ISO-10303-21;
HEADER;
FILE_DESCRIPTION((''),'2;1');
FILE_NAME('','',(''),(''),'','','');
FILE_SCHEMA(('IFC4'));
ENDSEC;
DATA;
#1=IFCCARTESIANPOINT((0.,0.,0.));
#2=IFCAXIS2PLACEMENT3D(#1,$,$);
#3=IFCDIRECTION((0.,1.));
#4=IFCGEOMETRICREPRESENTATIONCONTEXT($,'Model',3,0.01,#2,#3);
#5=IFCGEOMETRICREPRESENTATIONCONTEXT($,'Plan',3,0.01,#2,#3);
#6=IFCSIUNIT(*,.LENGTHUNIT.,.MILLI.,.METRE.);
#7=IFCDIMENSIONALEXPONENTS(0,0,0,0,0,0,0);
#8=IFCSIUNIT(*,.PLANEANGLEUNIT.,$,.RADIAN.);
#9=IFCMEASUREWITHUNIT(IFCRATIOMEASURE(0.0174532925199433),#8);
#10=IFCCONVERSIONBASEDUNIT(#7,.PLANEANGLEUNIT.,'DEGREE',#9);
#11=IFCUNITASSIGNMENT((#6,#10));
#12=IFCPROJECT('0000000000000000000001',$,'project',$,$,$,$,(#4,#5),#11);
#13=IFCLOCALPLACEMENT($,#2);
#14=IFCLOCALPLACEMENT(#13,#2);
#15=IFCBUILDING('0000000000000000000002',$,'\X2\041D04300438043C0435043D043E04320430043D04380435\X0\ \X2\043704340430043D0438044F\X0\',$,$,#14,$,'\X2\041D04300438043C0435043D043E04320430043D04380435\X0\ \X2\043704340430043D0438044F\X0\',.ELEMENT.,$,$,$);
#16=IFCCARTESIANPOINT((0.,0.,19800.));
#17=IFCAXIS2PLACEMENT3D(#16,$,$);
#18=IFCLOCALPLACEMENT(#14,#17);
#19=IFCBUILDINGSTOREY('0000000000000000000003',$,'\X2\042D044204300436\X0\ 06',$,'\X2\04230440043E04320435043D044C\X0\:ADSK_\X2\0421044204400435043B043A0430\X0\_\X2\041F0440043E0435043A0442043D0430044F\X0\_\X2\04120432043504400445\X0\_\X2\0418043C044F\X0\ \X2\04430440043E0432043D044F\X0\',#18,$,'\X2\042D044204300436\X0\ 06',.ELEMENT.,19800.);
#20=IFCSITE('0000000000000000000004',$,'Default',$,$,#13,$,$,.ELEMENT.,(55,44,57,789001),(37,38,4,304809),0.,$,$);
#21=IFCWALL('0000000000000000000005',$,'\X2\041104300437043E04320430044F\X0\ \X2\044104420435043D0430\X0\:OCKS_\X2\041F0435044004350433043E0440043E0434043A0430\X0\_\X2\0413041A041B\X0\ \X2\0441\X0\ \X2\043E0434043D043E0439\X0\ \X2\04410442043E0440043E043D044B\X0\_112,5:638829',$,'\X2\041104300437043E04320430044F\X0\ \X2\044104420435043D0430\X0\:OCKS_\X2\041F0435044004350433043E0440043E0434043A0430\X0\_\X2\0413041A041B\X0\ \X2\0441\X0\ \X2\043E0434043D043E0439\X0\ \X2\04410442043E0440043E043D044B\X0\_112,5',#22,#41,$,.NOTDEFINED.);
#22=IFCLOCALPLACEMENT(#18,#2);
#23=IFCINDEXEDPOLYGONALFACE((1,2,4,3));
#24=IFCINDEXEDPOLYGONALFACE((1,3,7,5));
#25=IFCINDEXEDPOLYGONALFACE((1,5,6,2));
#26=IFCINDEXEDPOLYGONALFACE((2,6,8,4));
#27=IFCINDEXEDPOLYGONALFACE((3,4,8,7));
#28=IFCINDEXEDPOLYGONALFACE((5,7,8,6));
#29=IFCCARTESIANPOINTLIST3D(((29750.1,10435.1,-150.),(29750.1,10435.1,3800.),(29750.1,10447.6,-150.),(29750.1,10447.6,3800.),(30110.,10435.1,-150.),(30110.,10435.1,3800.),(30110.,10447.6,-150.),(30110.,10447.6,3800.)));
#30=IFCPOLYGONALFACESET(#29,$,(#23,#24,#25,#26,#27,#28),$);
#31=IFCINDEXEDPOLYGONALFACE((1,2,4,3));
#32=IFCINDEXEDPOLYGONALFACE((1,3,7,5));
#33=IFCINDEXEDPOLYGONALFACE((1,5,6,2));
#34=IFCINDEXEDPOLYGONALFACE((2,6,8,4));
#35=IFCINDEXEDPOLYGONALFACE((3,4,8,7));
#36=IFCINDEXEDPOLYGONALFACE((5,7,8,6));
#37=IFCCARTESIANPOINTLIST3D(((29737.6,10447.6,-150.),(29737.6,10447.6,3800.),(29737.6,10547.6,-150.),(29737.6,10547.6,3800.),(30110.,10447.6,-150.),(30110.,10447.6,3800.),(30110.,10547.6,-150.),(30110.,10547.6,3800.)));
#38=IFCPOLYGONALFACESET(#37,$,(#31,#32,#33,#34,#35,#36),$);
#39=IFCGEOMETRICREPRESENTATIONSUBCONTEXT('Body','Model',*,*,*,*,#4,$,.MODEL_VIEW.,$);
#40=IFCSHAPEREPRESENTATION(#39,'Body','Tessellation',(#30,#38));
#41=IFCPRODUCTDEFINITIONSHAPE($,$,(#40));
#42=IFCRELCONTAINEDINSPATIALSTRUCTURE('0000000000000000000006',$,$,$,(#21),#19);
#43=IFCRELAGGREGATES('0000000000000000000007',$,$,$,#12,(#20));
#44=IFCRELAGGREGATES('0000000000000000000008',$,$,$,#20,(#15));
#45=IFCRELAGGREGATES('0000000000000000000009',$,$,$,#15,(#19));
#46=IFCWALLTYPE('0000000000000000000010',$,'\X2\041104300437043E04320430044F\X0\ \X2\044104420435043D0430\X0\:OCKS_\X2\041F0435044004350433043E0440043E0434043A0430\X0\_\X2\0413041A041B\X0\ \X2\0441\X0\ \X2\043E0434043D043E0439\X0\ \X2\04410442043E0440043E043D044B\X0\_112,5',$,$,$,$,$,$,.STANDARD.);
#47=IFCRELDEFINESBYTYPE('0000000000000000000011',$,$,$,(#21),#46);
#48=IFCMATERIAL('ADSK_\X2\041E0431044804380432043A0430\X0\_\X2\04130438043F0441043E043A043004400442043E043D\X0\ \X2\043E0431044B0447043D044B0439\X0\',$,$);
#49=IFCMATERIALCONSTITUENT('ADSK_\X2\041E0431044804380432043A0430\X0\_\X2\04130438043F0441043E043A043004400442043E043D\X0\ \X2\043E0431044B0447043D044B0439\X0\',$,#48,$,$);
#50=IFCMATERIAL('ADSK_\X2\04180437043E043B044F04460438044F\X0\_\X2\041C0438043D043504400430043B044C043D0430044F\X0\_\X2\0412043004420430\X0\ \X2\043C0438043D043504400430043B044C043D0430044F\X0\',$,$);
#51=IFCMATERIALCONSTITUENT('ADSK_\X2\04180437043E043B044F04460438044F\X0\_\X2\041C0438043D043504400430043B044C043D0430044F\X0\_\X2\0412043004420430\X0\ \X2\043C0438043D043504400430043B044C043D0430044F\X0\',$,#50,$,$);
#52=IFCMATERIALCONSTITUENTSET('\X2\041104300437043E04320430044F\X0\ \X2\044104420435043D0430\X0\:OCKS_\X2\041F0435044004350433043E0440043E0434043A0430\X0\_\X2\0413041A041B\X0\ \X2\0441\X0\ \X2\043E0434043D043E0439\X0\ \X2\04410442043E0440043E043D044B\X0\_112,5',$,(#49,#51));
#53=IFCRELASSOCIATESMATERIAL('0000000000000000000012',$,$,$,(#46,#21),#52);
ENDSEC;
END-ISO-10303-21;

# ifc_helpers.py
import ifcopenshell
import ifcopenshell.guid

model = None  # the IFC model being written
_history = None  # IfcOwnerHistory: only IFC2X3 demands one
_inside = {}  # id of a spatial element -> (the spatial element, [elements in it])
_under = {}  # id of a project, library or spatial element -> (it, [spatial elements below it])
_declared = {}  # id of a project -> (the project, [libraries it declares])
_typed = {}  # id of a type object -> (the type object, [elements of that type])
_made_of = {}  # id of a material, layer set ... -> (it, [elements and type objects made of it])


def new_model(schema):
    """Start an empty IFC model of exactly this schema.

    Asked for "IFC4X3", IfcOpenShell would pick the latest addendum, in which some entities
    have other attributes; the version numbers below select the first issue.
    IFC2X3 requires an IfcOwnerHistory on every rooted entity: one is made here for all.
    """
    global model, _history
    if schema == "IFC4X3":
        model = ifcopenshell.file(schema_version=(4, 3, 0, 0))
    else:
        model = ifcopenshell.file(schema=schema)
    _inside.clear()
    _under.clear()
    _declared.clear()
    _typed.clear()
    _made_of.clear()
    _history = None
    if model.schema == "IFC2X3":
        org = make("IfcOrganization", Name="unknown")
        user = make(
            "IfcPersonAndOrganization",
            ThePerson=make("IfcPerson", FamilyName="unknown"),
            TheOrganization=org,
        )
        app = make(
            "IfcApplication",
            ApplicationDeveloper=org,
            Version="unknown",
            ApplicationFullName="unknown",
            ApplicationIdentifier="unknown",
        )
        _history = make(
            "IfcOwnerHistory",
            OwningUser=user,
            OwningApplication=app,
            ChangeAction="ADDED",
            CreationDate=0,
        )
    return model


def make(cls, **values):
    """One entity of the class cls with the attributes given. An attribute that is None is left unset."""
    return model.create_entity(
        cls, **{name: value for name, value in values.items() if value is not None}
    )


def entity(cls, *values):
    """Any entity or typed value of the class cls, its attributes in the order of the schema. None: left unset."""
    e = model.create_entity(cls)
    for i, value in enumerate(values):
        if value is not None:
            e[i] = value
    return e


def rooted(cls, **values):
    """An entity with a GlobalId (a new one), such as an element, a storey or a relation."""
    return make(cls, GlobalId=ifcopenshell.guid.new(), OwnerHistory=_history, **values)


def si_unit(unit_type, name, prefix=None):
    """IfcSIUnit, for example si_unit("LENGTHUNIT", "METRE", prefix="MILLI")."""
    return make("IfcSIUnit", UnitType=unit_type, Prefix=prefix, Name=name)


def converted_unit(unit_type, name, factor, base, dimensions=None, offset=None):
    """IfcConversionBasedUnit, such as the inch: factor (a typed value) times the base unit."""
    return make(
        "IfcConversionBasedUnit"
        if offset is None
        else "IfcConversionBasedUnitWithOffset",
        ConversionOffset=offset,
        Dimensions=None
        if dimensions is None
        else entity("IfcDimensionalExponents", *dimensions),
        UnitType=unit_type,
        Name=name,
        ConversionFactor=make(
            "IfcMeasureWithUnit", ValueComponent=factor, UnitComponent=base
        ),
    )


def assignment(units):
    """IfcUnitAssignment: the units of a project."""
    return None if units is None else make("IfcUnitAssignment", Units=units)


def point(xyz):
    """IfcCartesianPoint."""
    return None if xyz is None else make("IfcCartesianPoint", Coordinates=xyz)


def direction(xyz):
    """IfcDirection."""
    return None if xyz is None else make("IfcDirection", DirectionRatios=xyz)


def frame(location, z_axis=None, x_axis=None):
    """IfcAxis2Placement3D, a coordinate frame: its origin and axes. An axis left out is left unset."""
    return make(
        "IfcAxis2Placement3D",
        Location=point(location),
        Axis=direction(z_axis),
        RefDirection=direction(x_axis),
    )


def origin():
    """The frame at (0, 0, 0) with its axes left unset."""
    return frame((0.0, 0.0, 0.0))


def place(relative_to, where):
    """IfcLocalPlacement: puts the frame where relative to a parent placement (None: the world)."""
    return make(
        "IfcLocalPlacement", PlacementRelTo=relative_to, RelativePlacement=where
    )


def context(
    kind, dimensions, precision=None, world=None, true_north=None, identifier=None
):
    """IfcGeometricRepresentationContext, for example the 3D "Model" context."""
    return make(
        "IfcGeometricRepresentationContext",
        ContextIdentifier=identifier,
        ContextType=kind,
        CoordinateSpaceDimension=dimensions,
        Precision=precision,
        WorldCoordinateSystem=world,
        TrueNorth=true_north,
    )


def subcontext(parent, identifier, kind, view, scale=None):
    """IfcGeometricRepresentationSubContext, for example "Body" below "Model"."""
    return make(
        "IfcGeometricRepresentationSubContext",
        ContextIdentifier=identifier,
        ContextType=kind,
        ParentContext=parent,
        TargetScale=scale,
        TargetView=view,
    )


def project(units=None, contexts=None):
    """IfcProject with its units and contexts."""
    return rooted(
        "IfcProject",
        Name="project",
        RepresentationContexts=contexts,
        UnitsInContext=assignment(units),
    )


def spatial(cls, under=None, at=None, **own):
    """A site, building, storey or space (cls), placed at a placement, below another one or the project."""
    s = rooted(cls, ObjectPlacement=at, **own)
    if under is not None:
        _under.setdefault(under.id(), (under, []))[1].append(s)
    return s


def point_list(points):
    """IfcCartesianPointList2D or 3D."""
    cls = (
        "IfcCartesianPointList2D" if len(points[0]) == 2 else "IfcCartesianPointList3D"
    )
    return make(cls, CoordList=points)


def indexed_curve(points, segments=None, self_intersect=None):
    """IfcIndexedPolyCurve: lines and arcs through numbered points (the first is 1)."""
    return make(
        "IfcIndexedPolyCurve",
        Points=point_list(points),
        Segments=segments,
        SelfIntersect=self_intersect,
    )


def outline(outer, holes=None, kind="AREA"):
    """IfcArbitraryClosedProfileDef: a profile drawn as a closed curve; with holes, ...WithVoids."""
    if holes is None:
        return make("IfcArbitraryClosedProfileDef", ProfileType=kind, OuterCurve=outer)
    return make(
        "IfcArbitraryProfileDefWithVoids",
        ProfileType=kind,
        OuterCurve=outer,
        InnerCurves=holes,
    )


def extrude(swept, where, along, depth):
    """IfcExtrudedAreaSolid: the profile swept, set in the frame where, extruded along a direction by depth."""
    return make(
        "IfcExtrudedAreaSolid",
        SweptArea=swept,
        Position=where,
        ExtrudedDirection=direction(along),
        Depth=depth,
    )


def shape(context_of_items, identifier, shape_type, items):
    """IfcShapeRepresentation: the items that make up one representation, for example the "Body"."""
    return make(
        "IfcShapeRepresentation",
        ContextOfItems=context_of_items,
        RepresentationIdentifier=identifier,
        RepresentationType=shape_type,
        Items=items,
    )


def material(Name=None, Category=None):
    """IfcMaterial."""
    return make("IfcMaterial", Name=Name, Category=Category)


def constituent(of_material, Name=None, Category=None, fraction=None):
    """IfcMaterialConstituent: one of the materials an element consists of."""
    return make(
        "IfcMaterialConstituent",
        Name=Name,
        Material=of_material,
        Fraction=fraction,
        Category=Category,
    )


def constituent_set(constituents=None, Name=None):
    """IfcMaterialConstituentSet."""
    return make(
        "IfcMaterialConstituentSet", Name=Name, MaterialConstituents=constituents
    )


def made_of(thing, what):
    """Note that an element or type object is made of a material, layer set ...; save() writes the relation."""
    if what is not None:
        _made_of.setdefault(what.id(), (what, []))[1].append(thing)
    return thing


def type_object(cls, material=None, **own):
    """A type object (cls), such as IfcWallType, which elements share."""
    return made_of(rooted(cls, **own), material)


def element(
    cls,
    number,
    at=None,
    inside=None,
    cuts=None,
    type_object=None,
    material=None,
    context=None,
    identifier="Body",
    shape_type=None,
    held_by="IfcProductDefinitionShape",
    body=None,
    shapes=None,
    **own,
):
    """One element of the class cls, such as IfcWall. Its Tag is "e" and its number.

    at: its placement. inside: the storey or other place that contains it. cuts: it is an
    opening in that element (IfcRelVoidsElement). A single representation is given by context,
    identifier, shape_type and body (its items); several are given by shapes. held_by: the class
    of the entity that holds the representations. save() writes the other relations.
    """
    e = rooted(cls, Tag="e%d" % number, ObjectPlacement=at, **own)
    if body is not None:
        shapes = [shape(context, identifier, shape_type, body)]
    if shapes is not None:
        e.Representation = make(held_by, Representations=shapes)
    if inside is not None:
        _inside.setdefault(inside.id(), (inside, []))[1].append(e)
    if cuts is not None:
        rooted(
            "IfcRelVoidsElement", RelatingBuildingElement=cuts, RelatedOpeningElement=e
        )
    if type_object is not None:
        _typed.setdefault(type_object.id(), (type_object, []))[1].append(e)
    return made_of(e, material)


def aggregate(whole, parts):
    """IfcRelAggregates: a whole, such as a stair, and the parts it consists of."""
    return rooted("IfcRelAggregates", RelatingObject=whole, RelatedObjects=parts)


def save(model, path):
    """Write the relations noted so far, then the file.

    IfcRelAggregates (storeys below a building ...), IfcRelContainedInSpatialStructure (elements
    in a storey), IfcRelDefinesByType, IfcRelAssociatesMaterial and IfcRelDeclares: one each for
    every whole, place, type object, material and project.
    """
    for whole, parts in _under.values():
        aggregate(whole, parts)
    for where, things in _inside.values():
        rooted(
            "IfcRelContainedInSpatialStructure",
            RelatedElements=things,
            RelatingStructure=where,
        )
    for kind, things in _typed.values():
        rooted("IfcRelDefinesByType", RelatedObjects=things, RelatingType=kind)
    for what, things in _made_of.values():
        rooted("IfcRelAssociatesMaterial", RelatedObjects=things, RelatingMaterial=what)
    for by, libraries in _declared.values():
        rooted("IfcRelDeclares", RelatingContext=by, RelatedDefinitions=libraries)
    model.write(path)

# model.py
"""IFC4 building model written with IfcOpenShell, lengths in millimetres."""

from ifc_helpers import new_model, entity, si_unit, converted_unit, direction, frame, origin, place, context, subcontext, project, spatial, indexed_curve, outline, extrude, material, constituent, constituent_set, type_object, element, save


model = new_model("IFC4")

# Units and contexts
model_context = context("Model", 3, precision=0.01, world=origin(), true_north=direction((0.0, 1.0)))
plan_context = context("Plan", 3, precision=0.01, world=origin(), true_north=direction((0.0, 1.0)))
body_context = subcontext(model_context, "Body", "Model", "MODEL_VIEW")
ifc_project = project(units=[si_unit("LENGTHUNIT", "METRE", prefix="MILLI"), converted_unit("PLANEANGLEUNIT", "DEGREE", entity("IfcRatioMeasure", 0.0174532925199433), si_unit("PLANEANGLEUNIT", "RADIAN"), dimensions=[0, 0, 0, 0, 0, 0, 0])], contexts=[model_context, plan_context])

# Site, building, storey
site_placement = place(None, frame((0.0, 0.0, 0.0)))
site = spatial("IfcSite", under=ifc_project, at=site_placement, Name="Default", CompositionType="ELEMENT", RefLatitude=(55, 44, 57, 789001), RefLongitude=(37, 38, 4, 304809), RefElevation=0.0)
building_placement = place(site_placement, origin())
building = spatial("IfcBuilding", under=site, at=building_placement, Name="Наименование здания", LongName="Наименование здания", CompositionType="ELEMENT")
storey_placement = place(building_placement, frame((0.0, 0.0, 19800.0)))
storey = spatial("IfcBuildingStorey", under=building, at=storey_placement, Name="Этаж 06", ObjectType="Уровень:ADSK_Стрелка_Проектная_Вверх_Имя уровня", LongName="Этаж 06", CompositionType="ELEMENT", Elevation=19800.0)

# Shared definitions
ifc_material_1 = material(Name="ADSK_Обшивка_Гипсокартон обычный")
ifc_material_2 = material(Name="ADSK_Изоляция_Минеральная_Вата минеральная")

# Wall
ifc_constituent_1 = constituent(ifc_material_1, Name="ADSK_Обшивка_Гипсокартон обычный")
ifc_constituent_2 = constituent(ifc_material_2, Name="ADSK_Изоляция_Минеральная_Вата минеральная")
ifc_constituent_set_1 = constituent_set(constituents=[ifc_constituent_1, ifc_constituent_2], Name="Базовая стена:OCKS_Перегородка_ГКЛ с одной стороны_112,5")
wall_type_1 = type_object("IfcWallType", Name="Базовая стена:OCKS_Перегородка_ГКЛ с одной стороны_112,5", PredefinedType="STANDARD", material=ifc_constituent_set_1)
wall_1_placement = place(storey_placement, frame((30110.0, 10491.4, -150.0), z_axis=(0.0, 0.0, 1.0), x_axis=(-1.0, 0.0, 0.0)))
element("IfcWall", 1, at=wall_1_placement, inside=storey, type_object=wall_type_1, material=ifc_constituent_set_1, Name="Базовая стена:OCKS_Перегородка_ГКЛ с одной стороны_112,5:638829", ObjectType="Базовая стена:OCKS_Перегородка_ГКЛ с одной стороны_112,5", PredefinedType="NOTDEFINED", context=body_context, shape_type="SweptSolid", body=[
    extrude(outline(indexed_curve([(-6.3, -180.0), (6.2, -180.0), (6.3, 180.0), (-6.2, 180.0), (-6.3, -180.0)], self_intersect=False)), frame((180.0, 50.0, 0.0), z_axis=(0.0, 0.0, 1.0), x_axis=(0.0, -1.0, 0.0)), (0.0, 0.0, 1.0), 3950.0),
    extrude(outline(indexed_curve([(-50.0, -186.2), (50.0, -186.2), (50.0, 186.2), (-50.0, 186.2), (-50.0, -186.2)], self_intersect=False)), frame((186.2, -6.3, 0.0), z_axis=(0.0, 0.0, 1.0), x_axis=(0.0, 1.0, 0.0)), (0.0, 0.0, 1.0), 3950.0),
])

save(model, "model.ifc")
